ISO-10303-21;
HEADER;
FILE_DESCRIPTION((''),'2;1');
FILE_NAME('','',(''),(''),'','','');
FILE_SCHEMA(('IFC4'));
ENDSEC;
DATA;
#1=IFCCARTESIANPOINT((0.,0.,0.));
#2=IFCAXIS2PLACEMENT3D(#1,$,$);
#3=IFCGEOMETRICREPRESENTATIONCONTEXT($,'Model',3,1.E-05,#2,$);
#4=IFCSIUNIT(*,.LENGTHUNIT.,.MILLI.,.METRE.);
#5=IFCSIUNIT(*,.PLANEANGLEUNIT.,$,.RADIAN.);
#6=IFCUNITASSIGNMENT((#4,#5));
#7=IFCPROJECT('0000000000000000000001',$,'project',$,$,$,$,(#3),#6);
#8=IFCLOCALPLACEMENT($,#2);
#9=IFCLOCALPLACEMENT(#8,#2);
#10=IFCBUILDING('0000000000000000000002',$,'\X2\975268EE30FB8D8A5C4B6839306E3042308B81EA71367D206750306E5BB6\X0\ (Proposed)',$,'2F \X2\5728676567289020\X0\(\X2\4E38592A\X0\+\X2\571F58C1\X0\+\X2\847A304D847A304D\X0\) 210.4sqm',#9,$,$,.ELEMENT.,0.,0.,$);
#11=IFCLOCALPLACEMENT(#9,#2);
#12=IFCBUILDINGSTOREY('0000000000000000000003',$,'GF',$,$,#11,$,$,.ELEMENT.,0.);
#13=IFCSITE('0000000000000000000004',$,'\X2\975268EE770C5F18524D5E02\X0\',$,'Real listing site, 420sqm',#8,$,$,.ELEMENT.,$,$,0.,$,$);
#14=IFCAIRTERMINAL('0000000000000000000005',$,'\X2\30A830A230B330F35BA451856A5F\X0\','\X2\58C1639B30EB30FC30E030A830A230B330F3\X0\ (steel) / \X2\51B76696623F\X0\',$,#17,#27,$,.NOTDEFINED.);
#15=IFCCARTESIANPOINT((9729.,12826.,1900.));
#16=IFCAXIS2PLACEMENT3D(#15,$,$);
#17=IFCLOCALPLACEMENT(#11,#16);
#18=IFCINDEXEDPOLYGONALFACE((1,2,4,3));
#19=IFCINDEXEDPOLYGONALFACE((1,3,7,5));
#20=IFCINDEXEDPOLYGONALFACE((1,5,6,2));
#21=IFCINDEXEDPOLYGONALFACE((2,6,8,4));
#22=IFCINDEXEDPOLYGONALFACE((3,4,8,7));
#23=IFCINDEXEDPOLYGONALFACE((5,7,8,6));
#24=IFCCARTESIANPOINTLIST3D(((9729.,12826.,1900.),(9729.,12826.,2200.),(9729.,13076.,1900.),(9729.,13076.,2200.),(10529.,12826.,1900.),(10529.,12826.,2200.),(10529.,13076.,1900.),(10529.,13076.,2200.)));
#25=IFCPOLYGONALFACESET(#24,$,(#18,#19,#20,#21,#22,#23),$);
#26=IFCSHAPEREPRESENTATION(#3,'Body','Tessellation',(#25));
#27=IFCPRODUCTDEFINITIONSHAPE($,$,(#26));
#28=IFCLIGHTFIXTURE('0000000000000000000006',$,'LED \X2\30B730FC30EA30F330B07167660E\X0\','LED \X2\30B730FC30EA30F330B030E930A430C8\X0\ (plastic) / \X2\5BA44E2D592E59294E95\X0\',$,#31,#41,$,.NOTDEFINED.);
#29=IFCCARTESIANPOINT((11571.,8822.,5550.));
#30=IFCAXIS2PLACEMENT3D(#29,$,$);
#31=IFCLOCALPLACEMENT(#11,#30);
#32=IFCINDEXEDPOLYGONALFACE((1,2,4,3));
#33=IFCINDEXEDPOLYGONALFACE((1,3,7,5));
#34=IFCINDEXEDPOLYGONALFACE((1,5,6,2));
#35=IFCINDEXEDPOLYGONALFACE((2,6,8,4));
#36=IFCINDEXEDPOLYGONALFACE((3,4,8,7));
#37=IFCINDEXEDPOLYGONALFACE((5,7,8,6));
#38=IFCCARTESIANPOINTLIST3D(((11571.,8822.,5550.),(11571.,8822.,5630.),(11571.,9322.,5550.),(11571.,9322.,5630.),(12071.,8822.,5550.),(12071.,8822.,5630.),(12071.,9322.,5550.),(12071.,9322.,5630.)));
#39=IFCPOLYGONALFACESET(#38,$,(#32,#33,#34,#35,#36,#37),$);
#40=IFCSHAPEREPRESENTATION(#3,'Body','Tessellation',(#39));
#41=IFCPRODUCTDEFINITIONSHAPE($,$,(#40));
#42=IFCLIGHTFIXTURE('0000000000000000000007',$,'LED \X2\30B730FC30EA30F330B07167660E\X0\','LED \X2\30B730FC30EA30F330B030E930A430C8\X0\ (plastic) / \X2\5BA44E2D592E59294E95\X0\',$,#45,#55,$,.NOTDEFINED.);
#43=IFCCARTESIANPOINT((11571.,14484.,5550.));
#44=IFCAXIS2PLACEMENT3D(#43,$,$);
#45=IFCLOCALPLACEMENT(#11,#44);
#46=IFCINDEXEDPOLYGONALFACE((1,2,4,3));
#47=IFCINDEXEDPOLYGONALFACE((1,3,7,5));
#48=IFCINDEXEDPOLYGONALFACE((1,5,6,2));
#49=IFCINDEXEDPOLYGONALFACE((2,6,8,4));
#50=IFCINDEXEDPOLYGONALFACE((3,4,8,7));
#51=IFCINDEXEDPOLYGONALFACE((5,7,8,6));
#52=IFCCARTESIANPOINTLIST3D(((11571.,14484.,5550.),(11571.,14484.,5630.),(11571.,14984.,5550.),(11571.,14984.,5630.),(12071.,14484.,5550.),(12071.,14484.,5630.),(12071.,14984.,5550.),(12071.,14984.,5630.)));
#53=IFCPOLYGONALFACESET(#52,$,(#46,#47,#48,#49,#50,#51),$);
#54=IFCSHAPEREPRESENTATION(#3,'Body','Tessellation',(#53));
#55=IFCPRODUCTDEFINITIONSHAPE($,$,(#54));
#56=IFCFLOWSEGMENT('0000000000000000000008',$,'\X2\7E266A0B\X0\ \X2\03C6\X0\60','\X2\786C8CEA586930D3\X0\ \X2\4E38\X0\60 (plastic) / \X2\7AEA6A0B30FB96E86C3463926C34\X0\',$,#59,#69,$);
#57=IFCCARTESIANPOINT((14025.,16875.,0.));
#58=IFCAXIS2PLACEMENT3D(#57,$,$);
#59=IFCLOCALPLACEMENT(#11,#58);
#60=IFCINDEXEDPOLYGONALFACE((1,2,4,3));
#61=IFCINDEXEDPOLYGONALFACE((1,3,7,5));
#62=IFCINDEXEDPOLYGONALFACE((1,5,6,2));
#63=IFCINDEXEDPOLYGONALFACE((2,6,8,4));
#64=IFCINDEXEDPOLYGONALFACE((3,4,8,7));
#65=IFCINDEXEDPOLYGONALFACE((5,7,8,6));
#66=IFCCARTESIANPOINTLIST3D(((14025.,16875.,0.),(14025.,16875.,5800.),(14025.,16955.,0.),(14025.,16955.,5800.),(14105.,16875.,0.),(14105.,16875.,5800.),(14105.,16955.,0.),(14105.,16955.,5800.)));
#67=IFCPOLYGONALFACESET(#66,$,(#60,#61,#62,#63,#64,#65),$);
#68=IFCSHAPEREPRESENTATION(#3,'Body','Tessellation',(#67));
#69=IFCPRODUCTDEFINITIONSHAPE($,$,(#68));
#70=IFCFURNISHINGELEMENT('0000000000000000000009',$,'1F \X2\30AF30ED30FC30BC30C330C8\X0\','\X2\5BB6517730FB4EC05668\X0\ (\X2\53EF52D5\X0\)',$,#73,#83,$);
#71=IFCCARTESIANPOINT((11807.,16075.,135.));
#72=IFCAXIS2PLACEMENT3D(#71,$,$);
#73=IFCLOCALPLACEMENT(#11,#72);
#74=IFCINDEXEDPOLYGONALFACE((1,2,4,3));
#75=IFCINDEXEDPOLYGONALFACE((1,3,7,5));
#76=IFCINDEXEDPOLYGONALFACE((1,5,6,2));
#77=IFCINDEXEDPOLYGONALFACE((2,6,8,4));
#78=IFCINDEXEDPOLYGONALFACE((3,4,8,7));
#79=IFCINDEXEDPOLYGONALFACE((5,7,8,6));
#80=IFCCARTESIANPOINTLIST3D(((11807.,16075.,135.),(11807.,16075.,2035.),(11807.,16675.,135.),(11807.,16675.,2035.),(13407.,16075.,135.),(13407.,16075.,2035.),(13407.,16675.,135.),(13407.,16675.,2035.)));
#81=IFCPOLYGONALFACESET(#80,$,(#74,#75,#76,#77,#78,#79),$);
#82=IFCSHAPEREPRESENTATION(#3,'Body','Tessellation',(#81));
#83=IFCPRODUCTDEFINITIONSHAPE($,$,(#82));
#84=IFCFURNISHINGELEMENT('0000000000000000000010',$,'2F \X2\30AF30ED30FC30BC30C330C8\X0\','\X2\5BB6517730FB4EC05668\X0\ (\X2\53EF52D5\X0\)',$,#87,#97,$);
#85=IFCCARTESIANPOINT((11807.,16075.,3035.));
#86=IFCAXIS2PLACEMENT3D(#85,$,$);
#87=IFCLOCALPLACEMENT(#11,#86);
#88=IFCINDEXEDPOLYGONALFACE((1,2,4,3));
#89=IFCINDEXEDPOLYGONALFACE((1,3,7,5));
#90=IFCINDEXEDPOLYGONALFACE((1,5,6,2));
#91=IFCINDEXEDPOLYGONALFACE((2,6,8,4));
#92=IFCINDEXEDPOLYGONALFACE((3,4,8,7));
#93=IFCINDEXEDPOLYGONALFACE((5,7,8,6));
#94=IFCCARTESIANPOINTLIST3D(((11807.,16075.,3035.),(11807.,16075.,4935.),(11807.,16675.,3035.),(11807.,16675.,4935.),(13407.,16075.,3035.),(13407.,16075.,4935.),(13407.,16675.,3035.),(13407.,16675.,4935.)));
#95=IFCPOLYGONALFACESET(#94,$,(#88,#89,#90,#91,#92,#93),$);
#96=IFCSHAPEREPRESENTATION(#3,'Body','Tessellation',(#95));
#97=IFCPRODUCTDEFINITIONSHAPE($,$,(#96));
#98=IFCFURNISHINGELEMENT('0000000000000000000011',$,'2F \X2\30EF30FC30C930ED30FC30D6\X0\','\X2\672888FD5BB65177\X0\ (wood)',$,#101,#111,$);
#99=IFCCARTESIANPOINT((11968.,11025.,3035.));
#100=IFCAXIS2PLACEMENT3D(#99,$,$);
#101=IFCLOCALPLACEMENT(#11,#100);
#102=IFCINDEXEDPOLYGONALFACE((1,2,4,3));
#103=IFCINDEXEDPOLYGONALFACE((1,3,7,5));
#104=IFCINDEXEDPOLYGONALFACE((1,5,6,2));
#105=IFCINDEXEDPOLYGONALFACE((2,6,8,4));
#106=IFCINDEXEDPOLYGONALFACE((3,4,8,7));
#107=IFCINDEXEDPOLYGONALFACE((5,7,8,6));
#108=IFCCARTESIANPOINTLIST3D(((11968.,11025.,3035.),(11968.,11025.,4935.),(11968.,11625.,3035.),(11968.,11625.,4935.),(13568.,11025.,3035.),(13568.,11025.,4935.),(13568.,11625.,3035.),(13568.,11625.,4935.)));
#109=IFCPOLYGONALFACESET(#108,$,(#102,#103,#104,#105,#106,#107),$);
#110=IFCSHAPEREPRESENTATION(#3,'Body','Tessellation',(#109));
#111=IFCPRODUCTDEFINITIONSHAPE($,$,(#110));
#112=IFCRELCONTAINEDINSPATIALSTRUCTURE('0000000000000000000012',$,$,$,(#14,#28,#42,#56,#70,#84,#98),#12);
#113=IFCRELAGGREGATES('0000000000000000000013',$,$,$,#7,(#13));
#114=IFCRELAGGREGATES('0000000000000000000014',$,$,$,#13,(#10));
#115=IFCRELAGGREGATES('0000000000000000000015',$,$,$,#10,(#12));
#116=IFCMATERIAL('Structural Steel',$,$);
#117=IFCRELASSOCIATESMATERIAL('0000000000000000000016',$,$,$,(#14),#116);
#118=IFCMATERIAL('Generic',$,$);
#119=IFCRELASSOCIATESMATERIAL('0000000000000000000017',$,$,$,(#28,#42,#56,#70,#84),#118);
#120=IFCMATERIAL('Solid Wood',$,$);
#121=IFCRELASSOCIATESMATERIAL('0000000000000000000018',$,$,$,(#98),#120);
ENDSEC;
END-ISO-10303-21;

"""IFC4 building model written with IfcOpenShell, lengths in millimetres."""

from ifc_helpers import new_model, si_unit, frame, frame_2d, origin, place, context, project, spatial, rectangle, extrude, material, element, save


model = new_model("IFC4")

# Units and contexts
model_context = context("Model", 3, precision=1e-05, world=origin())
ifc_project = project(units=[si_unit("LENGTHUNIT", "METRE", prefix="MILLI"), si_unit("PLANEANGLEUNIT", "RADIAN")], contexts=[model_context])

# Site, building, storey
site_placement = place(None, origin())
site = spatial("IfcSite", under=ifc_project, at=site_placement, Name="青森県弘前市", ObjectType="Real listing site, 420sqm", CompositionType="ELEMENT", RefElevation=0.0)
building_placement = place(site_placement, origin())
building = spatial("IfcBuilding", under=site, at=building_placement, Name="青森・越屋根のある自然素材の家 (Proposed)", ObjectType="2F 在来木造(丸太+土壁+葺き葺き) 210.4sqm", CompositionType="ELEMENT", ElevationOfRefHeight=0.0, ElevationOfTerrain=0.0)
storey_placement = place(building_placement, origin())
storey = spatial("IfcBuildingStorey", under=building, at=storey_placement, Name="GF", CompositionType="ELEMENT", Elevation=0.0)

# Shared definitions
ifc_material_1 = material(Name="Solid Wood")

# Shared definitions
ifc_material_2 = material(Name="Structural Steel")

# Shared definitions
ifc_material_3 = material(Name="Generic")

# Air terminal
air_terminal_placement = place(storey_placement, frame((9729.0, 12826.0, 1900.0)))
element("IfcAirTerminal", 1, at=air_terminal_placement, inside=storey, material=ifc_material_2, Name="エアコン室内機", Description="壁掛ルームエアコン (steel) / 冷暖房", PredefinedType="NOTDEFINED", context=model_context, shape_type="SweptSolid", body=[
    extrude(rectangle(XDim=800.0, YDim=250.0, at=frame_2d((400.0, 125.0))), frame((9729.0, 12826.0, 1900.0)), (0.0, 0.0, 1.0), 300.0),
])

# Light fixtures
light_fixture_1_placement = place(storey_placement, frame((11571.0, 8822.0, 5550.0)))
element("IfcLightFixture", 2, at=light_fixture_1_placement, inside=storey, material=ifc_material_3, Name="LED シーリング照明", Description="LED シーリングライト (plastic) / 室中央天井", PredefinedType="NOTDEFINED", context=model_context, shape_type="SweptSolid", body=[
    extrude(rectangle(XDim=500.0, YDim=500.0, at=frame_2d((250.0, 250.0))), frame((11571.0, 8822.0, 5550.0)), (0.0, 0.0, 1.0), 80.0),
])
light_fixture_2_placement = place(storey_placement, frame((11571.0, 14484.0, 5550.0)))
element("IfcLightFixture", 3, at=light_fixture_2_placement, inside=storey, material=ifc_material_3, Name="LED シーリング照明", Description="LED シーリングライト (plastic) / 室中央天井", PredefinedType="NOTDEFINED", context=model_context, shape_type="SweptSolid", body=[
    extrude(rectangle(XDim=500.0, YDim=500.0, at=frame_2d((250.0, 250.0))), frame((11571.0, 14484.0, 5550.0)), (0.0, 0.0, 1.0), 80.0),
])

# Flow segment
flow_segment_placement = place(storey_placement, frame((14025.0, 16875.0, 0.0)))
element("IfcFlowSegment", 4, at=flow_segment_placement, inside=storey, material=ifc_material_3, Name="縦樋 φ60", Description="硬質塩ビ 丸60 (plastic) / 竪樋・雨水排水", context=model_context, shape_type="SweptSolid", body=[
    extrude(rectangle(XDim=80.0, YDim=80.0, at=frame_2d((40.0, 40.0))), frame((14025.0, 16875.0, 0.0)), (0.0, 0.0, 1.0), 5800.0),
])

# Furnishing elements
furnishing_1_placement = place(storey_placement, frame((11807.0, 16075.0, 135.0)))
element("IfcFurnishingElement", 5, at=furnishing_1_placement, inside=storey, material=ifc_material_3, Name="1F クローゼット", Description="家具・什器 (可動)", context=model_context, shape_type="SweptSolid", body=[
    extrude(rectangle(XDim=1600.0, YDim=600.0, at=frame_2d((800.0, 300.0))), frame((11807.0, 16075.0, 135.0)), (0.0, 0.0, 1.0), 1900.0),
])
furnishing_2_placement = place(storey_placement, frame((11807.0, 16075.0, 3035.0)))
element("IfcFurnishingElement", 6, at=furnishing_2_placement, inside=storey, material=ifc_material_3, Name="2F クローゼット", Description="家具・什器 (可動)", context=model_context, shape_type="SweptSolid", body=[
    extrude(rectangle(XDim=1600.0, YDim=600.0, at=frame_2d((800.0, 300.0))), frame((11807.0, 16075.0, 3035.0)), (0.0, 0.0, 1.0), 1900.0),
])
furnishing_3_placement = place(storey_placement, frame((11968.0, 11025.0, 3035.0)))
element("IfcFurnishingElement", 7, at=furnishing_3_placement, inside=storey, material=ifc_material_1, Name="2F ワードローブ", Description="木製家具 (wood)", context=model_context, shape_type="SweptSolid", body=[
    extrude(rectangle(XDim=1600.0, YDim=600.0, at=frame_2d((800.0, 300.0))), frame((11968.0, 11025.0, 3035.0)), (0.0, 0.0, 1.0), 1900.0),
])

save(model, "model.ifc")
